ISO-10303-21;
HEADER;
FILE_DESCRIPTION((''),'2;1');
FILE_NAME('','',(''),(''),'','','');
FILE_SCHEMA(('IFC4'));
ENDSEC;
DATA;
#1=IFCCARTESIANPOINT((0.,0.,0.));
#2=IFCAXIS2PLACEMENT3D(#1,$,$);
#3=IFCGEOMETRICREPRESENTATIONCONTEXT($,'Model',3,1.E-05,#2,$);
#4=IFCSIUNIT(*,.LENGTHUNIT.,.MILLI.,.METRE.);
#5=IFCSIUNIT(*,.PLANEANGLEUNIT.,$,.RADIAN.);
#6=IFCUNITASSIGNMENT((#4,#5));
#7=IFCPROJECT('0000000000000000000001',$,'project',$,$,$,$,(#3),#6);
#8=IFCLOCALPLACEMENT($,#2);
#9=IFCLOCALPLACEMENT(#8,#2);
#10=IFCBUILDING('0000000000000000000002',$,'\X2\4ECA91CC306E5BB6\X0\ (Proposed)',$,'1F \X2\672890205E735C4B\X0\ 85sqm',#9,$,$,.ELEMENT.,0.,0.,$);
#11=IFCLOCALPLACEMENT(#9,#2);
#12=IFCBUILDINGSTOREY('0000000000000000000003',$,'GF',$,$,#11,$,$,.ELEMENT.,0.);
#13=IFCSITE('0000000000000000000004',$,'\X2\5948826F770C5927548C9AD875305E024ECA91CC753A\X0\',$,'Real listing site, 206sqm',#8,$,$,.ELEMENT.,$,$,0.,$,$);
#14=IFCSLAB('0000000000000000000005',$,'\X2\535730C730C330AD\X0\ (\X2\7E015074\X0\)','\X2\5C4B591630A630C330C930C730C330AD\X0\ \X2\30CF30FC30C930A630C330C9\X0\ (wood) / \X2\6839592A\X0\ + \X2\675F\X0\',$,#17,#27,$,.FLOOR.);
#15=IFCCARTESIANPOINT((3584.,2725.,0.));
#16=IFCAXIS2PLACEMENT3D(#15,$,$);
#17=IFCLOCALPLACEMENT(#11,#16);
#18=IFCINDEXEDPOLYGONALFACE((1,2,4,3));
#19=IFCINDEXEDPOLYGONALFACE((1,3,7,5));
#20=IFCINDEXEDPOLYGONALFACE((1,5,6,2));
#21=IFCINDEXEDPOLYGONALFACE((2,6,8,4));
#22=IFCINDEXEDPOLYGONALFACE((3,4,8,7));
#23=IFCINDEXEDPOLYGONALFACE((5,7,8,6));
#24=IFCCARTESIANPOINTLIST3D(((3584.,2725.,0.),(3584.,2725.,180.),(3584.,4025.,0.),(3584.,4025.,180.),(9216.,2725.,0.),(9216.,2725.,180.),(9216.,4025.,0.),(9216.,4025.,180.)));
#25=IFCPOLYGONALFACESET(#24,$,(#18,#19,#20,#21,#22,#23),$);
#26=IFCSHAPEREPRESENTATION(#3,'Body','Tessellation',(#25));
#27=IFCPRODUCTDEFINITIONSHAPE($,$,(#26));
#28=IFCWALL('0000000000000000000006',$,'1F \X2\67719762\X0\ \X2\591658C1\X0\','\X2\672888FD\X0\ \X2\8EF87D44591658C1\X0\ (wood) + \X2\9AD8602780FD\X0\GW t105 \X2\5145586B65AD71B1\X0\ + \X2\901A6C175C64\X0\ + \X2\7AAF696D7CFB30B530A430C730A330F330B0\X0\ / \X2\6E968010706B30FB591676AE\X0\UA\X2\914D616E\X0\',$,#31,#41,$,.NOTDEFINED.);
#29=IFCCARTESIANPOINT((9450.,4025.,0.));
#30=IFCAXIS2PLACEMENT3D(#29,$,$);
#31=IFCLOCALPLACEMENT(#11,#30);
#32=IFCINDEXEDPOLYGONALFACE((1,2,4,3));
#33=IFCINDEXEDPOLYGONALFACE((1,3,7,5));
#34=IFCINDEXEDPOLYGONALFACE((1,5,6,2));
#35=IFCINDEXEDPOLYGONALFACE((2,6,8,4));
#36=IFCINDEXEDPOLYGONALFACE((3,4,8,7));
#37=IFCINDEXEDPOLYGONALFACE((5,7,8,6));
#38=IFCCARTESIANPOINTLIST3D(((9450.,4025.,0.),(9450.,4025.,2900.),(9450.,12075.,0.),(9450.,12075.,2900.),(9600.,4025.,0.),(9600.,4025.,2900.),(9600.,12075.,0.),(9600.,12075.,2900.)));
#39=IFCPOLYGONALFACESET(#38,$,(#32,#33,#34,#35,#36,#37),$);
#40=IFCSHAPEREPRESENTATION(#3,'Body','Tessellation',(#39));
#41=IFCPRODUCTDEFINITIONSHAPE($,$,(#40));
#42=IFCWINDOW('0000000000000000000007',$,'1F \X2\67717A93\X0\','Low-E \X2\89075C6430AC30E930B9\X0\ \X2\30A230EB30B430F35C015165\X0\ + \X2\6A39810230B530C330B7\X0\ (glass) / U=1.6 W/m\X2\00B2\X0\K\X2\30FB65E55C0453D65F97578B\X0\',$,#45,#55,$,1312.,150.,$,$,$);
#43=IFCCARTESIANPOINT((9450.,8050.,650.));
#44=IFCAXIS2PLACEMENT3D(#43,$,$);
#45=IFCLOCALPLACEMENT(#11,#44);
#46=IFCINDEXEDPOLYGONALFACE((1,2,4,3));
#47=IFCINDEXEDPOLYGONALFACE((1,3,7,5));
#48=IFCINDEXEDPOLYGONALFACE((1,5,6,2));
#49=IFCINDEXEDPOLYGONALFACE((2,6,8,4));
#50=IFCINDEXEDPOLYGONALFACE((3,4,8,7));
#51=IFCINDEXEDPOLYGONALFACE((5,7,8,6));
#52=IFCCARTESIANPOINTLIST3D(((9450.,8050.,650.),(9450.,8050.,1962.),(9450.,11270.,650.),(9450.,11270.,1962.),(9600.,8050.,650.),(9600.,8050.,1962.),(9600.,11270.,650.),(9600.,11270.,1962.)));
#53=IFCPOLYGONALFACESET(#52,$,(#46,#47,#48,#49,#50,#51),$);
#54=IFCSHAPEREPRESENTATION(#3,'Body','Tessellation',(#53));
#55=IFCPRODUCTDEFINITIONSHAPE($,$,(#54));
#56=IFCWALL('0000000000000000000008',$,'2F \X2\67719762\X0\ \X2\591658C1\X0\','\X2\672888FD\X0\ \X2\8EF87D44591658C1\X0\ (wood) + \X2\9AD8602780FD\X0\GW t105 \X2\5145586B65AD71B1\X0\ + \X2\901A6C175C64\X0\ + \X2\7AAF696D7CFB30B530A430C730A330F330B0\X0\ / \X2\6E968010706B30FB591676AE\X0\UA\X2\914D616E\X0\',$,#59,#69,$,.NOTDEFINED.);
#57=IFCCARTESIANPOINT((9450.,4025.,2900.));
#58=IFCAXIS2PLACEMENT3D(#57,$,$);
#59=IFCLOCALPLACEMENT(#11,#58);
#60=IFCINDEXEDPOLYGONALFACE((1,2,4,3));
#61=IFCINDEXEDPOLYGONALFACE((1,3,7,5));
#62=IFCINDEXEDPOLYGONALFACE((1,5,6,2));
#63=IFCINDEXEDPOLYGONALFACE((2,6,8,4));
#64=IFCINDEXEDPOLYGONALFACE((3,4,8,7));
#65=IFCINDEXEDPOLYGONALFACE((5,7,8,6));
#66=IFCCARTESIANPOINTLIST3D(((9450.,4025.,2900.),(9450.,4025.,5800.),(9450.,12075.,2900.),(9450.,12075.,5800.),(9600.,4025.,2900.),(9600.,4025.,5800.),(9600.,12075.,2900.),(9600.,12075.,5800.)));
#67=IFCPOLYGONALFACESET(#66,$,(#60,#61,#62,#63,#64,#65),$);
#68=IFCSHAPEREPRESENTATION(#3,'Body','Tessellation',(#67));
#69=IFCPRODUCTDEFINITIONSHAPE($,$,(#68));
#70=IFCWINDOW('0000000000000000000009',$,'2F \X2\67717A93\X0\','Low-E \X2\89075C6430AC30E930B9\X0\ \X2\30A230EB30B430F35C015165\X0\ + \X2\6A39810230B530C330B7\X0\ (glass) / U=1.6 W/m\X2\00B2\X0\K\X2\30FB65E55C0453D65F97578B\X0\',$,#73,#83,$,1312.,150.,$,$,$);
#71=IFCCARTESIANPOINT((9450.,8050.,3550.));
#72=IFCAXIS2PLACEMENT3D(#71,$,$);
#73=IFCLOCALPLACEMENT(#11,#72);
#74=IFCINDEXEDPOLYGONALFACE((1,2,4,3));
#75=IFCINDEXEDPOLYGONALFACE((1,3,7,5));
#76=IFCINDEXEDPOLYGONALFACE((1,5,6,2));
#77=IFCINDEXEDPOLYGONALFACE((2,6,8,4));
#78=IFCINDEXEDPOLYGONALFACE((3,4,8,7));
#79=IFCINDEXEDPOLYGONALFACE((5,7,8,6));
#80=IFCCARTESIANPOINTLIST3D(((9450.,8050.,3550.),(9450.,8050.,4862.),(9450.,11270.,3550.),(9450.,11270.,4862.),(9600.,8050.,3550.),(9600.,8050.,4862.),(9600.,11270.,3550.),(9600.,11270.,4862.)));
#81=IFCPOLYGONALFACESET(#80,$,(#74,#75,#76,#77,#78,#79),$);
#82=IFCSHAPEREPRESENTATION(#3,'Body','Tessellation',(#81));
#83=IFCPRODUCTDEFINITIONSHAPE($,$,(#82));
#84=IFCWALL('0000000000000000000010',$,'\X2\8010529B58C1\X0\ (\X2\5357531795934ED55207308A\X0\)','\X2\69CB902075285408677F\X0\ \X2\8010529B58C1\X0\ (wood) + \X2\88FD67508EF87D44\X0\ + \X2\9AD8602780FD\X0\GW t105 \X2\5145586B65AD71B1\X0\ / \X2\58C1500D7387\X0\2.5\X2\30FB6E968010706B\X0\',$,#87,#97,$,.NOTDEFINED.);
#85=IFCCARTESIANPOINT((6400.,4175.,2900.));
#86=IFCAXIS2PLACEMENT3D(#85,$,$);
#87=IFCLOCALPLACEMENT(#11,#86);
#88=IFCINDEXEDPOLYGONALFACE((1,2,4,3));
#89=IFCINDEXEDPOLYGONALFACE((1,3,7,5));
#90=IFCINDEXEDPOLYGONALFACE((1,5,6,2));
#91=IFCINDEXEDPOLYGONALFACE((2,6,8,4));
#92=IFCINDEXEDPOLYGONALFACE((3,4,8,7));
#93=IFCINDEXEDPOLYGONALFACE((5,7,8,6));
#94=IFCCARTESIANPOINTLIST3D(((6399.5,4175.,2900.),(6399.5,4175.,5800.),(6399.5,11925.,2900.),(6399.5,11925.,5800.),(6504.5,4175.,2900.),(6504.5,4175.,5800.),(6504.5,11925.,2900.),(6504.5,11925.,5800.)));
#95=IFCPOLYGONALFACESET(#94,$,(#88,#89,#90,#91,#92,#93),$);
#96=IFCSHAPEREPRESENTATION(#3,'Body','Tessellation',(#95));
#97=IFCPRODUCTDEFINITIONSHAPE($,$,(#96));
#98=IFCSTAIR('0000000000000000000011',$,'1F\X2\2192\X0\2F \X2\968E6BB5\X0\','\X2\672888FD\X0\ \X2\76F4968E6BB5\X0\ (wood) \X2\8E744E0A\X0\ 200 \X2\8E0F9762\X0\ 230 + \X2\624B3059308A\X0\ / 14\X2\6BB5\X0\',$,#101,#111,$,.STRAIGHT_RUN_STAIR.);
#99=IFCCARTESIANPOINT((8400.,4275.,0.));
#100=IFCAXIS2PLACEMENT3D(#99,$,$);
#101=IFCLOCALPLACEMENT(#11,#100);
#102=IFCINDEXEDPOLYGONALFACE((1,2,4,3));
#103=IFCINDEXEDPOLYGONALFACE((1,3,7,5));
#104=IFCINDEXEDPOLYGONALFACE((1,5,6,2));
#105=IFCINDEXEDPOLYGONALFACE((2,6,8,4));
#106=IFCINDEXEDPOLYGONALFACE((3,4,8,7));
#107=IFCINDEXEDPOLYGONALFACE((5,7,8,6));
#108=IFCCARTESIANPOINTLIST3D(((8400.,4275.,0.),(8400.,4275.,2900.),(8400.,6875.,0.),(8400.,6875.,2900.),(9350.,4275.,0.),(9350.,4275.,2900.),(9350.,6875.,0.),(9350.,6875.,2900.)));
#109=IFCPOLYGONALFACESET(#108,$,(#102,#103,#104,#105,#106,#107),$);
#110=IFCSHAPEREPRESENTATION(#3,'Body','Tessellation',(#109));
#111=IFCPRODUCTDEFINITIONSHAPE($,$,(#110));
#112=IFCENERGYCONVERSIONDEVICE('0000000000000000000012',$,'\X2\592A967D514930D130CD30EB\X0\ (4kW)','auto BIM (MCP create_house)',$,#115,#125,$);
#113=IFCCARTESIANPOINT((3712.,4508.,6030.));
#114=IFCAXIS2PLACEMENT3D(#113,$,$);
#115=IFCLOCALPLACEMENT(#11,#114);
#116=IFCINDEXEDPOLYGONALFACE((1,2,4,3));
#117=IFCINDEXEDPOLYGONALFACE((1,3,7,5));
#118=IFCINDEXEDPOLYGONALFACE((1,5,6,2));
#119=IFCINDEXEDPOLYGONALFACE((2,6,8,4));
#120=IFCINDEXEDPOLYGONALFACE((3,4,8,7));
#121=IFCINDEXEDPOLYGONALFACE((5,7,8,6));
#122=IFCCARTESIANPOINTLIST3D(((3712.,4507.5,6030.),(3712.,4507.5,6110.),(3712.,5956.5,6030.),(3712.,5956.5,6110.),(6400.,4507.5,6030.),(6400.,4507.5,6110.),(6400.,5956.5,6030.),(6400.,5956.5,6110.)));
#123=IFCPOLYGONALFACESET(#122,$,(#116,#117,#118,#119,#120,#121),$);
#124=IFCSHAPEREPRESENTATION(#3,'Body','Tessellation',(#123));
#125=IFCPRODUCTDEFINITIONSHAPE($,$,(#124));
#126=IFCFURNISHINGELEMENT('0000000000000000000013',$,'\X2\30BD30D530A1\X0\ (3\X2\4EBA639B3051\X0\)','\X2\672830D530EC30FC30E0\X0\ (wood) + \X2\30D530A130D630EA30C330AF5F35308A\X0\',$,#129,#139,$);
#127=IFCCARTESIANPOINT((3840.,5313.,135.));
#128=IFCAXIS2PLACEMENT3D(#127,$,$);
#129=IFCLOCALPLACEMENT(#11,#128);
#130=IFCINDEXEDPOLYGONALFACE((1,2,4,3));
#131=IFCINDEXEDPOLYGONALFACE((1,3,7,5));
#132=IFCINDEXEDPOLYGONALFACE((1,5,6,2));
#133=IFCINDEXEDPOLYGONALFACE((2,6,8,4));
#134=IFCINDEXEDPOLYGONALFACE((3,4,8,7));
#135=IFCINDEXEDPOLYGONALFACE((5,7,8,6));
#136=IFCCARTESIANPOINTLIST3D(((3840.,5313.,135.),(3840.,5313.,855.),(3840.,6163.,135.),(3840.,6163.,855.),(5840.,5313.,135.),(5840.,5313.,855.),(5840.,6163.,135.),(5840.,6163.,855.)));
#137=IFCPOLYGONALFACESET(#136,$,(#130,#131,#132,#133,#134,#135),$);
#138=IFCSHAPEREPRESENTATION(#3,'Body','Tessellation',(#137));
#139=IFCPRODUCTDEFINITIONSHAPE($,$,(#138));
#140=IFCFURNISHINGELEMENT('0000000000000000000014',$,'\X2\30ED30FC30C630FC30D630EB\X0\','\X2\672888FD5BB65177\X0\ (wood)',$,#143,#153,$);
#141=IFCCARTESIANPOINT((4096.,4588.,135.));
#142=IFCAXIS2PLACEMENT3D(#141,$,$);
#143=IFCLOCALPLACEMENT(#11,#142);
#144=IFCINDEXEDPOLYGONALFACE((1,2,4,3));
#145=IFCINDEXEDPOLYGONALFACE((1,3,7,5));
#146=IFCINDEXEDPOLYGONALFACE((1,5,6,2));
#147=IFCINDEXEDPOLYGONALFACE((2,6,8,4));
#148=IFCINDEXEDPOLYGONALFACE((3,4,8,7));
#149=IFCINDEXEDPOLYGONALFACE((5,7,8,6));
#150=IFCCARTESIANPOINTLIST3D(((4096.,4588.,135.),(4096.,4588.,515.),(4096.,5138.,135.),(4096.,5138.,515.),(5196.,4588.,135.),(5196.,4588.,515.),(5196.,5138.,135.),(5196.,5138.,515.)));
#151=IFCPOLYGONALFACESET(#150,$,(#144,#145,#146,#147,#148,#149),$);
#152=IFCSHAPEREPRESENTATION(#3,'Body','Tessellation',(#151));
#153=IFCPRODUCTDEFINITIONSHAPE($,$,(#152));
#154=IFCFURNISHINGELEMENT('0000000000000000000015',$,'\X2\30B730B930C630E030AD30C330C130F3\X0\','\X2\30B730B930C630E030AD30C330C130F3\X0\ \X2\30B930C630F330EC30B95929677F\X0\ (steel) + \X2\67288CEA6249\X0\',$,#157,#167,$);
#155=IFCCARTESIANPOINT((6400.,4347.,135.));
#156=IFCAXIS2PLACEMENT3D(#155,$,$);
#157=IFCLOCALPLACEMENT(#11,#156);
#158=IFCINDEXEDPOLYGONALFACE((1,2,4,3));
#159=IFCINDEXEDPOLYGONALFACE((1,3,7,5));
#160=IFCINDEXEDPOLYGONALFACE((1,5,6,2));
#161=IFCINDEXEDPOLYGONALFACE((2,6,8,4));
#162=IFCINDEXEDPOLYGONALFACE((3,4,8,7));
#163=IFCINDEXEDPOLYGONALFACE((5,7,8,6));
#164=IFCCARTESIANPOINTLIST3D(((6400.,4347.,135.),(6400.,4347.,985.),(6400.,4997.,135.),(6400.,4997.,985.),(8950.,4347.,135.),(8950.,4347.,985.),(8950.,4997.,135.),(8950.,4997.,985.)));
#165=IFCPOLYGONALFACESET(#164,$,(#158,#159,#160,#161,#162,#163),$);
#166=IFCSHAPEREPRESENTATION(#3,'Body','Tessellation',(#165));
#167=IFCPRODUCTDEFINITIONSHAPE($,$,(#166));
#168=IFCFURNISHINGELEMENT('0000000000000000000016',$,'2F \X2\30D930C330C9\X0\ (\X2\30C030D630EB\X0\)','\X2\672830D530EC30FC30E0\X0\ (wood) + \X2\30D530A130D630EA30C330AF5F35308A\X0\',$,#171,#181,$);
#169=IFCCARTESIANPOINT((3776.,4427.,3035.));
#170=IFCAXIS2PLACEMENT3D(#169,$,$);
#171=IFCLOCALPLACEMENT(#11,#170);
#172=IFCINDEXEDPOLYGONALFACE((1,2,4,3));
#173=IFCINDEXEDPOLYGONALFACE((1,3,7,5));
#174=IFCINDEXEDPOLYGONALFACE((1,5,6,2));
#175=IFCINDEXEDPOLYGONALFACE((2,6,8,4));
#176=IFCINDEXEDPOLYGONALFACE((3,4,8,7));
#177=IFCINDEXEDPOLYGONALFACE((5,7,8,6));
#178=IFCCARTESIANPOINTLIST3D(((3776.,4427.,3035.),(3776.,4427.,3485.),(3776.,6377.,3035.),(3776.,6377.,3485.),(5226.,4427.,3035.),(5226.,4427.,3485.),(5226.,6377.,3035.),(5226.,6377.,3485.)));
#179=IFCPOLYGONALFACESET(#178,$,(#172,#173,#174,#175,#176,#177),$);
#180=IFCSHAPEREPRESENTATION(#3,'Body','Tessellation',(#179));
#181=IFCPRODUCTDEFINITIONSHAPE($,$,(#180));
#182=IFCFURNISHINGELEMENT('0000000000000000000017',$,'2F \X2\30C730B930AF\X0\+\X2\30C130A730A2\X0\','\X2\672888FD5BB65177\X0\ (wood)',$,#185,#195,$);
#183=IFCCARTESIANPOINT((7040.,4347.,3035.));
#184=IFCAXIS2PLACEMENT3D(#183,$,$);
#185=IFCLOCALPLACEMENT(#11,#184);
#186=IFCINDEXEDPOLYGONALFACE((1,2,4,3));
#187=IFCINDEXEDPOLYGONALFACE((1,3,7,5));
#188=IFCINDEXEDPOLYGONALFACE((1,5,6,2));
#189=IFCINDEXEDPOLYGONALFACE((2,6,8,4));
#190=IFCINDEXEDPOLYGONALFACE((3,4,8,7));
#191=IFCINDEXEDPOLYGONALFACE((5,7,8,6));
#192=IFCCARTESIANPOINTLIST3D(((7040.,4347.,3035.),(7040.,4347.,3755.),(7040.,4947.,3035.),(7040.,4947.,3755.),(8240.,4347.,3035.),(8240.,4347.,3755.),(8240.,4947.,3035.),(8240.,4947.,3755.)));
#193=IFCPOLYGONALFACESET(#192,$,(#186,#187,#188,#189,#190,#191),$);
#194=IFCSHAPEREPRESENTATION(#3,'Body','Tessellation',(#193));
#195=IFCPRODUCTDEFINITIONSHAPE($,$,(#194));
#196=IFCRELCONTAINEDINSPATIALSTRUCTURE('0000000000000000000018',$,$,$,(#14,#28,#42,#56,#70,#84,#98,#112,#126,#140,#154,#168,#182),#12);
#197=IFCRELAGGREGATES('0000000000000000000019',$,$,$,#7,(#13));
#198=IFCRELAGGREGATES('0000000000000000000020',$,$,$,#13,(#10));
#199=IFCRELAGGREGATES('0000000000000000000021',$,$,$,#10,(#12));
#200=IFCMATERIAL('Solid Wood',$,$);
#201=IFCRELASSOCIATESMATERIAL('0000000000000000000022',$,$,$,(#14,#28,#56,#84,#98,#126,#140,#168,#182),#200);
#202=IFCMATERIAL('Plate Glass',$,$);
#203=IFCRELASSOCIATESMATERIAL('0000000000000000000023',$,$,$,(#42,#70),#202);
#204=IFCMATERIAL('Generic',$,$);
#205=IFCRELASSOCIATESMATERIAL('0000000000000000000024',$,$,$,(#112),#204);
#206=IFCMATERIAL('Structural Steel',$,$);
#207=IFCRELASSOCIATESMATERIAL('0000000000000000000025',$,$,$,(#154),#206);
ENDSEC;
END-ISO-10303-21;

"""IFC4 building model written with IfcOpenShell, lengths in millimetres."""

from ifc_helpers import new_model, si_unit, frame, frame_2d, origin, place, context, project, spatial, rectangle, extrude, material, element, fill, save


model = new_model("IFC4")

# Units and contexts
model_context = context("Model", 3, precision=1e-05, world=origin())
ifc_project = project(units=[si_unit("LENGTHUNIT", "METRE", prefix="MILLI"), si_unit("PLANEANGLEUNIT", "RADIAN")], contexts=[model_context])

# Site, building, storey
site_placement = place(None, origin())
site = spatial("IfcSite", under=ifc_project, at=site_placement, Name="奈良県大和高田市今里町", ObjectType="Real listing site, 206sqm", CompositionType="ELEMENT", RefElevation=0.0)
building_placement = place(site_placement, origin())
building = spatial("IfcBuilding", under=site, at=building_placement, Name="今里の家 (Proposed)", ObjectType="1F 木造平屋 85sqm", CompositionType="ELEMENT", ElevationOfRefHeight=0.0, ElevationOfTerrain=0.0)
storey_placement = place(building_placement, origin())
storey = spatial("IfcBuildingStorey", under=building, at=storey_placement, Name="GF", CompositionType="ELEMENT", Elevation=0.0)

# Slab
ifc_material_1 = material(Name="Solid Wood")
slab_placement = place(storey_placement, frame((3584.0, 2725.0, 0.0)))
element("IfcSlab", 1, at=slab_placement, inside=storey, material=ifc_material_1, Name="南デッキ (縁側)", Description="屋外ウッドデッキ ハードウッド (wood) / 根太 + 束", PredefinedType="FLOOR", context=model_context, shape_type="SweptSolid", body=[
    extrude(rectangle(XDim=5632.0, YDim=1300.0, at=frame_2d((2816.0, 650.0))), frame((3584.0, 2725.0, 0.0)), (0.0, 0.0, 1.0), 180.0),
])

# Wall, opening, window
wall_1_placement = place(storey_placement, frame((9450.0, 4025.0, 0.0)))
wall_1 = element("IfcWall", 2, at=wall_1_placement, inside=storey, material=ifc_material_1, Name="1F 東面 外壁", Description="木製 軸組外壁 (wood) + 高性能GW t105 充填断熱 + 通気層 + 窯業系サイディング / 準耐火・外皮UA配慮", PredefinedType="NOTDEFINED", context=model_context, shape_type="SweptSolid", body=[
    extrude(rectangle(XDim=150.0, YDim=8050.0, at=frame_2d((75.0, 4025.0))), frame((9450.0, 4025.0, 0.0)), (0.0, 0.0, 1.0), 2900.0),
])
opening_1_placement = place(storey_placement, frame((9450.0, 8050.0, 650.0)))
opening_1 = element("IfcOpeningElement", 3, at=opening_1_placement, cuts=wall_1, PredefinedType="NOTDEFINED", context=model_context, shape_type="SweptSolid", body=[
    extrude(rectangle(XDim=150.0, YDim=3220.0, at=frame_2d((75.0, 1610.0))), frame((9450.0, 8050.0, 650.0)), (0.0, 0.0, 1.0), 1312.0),
])
ifc_material_2 = material(Name="Plate Glass")
window_1_placement = place(storey_placement, frame((9450.0, 8050.0, 650.0)))
window_1 = element("IfcWindow", 4, at=window_1_placement, inside=storey, material=ifc_material_2, Name="1F 東窓", Description="Low-E 複層ガラス アルゴン封入 + 樹脂サッシ (glass) / U=1.6 W/m²K・日射取得型", OverallHeight=1312.0, OverallWidth=150.0, context=model_context, shape_type="SweptSolid", body=[
    extrude(rectangle(XDim=150.0, YDim=3220.0, at=frame_2d((75.0, 1610.0))), frame((9450.0, 8050.0, 650.0)), (0.0, 0.0, 1.0), 1312.0),
])
fill(opening_1, window_1)

# Wall, opening, window
wall_2_placement = place(storey_placement, frame((9450.0, 4025.0, 2900.0)))
wall_2 = element("IfcWall", 5, at=wall_2_placement, inside=storey, material=ifc_material_1, Name="2F 東面 外壁", Description="木製 軸組外壁 (wood) + 高性能GW t105 充填断熱 + 通気層 + 窯業系サイディング / 準耐火・外皮UA配慮", PredefinedType="NOTDEFINED", context=model_context, shape_type="SweptSolid", body=[
    extrude(rectangle(XDim=150.0, YDim=8050.0, at=frame_2d((75.0, 4025.0))), frame((9450.0, 4025.0, 2900.0)), (0.0, 0.0, 1.0), 2900.0),
])
opening_2_placement = place(storey_placement, frame((9450.0, 8050.0, 3550.0)))
opening_2 = element("IfcOpeningElement", 6, at=opening_2_placement, cuts=wall_2, PredefinedType="NOTDEFINED", context=model_context, shape_type="SweptSolid", body=[
    extrude(rectangle(XDim=150.0, YDim=3220.0, at=frame_2d((75.0, 1610.0))), frame((9450.0, 8050.0, 3550.0)), (0.0, 0.0, 1.0), 1312.0),
])
window_2_placement = place(storey_placement, frame((9450.0, 8050.0, 3550.0)))
window_2 = element("IfcWindow", 7, at=window_2_placement, inside=storey, material=ifc_material_2, Name="2F 東窓", Description="Low-E 複層ガラス アルゴン封入 + 樹脂サッシ (glass) / U=1.6 W/m²K・日射取得型", OverallHeight=1312.0, OverallWidth=150.0, context=model_context, shape_type="SweptSolid", body=[
    extrude(rectangle(XDim=150.0, YDim=3220.0, at=frame_2d((75.0, 1610.0))), frame((9450.0, 8050.0, 3550.0)), (0.0, 0.0, 1.0), 1312.0),
])
fill(opening_2, window_2)

# Wall
wall_3_placement = place(storey_placement, frame((6400.0, 4175.0, 2900.0)))
element("IfcWall", 8, at=wall_3_placement, inside=storey, material=ifc_material_1, Name="耐力壁 (南北間仕切り)", Description="構造用合板 耐力壁 (wood) + 製材軸組 + 高性能GW t105 充填断熱 / 壁倍率2.5・準耐火", PredefinedType="NOTDEFINED", context=model_context, shape_type="SweptSolid", body=[
    extrude(rectangle(XDim=105.0, YDim=7750.0, at=frame_2d((52.0, 3875.0))), frame((6400.0, 4175.0, 2900.0)), (0.0, 0.0, 1.0), 2900.0),
])

# Stair
stair_placement = place(storey_placement, frame((8400.0, 4275.0, 0.0)))
element("IfcStair", 9, at=stair_placement, inside=storey, material=ifc_material_1, Name="1F→2F 階段", Description="木製 直階段 (wood) 蹴上 200 踏面 230 + 手すり / 14段", PredefinedType="STRAIGHT_RUN_STAIR", context=model_context, shape_type="SweptSolid", body=[
    extrude(rectangle(XDim=950.0, YDim=2600.0, at=frame_2d((475.0, 1300.0))), frame((8400.0, 4275.0, 0.0)), (0.0, 0.0, 1.0), 2900.0),
])

# Energy conversion device
ifc_material_3 = material(Name="Generic")
energy_conversion_device_placement = place(storey_placement, frame((3712.0, 4508.0, 6030.0)))
element("IfcEnergyConversionDevice", 10, at=energy_conversion_device_placement, inside=storey, material=ifc_material_3, Name="太陽光パネル (4kW)", Description="auto BIM (MCP create_house)", context=model_context, shape_type="SweptSolid", body=[
    extrude(rectangle(XDim=2688.0, YDim=1449.0, at=frame_2d((1344.0, 724.0))), frame((3712.0, 4508.0, 6030.0)), (0.0, 0.0, 1.0), 80.0),
])

# Furnishing elements
furnishing_1_placement = place(storey_placement, frame((3840.0, 5313.0, 135.0)))
element("IfcFurnishingElement", 11, at=furnishing_1_placement, inside=storey, material=ifc_material_1, Name="ソファ (3人掛け)", Description="木フレーム (wood) + ファブリック張り", context=model_context, shape_type="SweptSolid", body=[
    extrude(rectangle(XDim=2000.0, YDim=850.0, at=frame_2d((1000.0, 425.0))), frame((3840.0, 5313.0, 135.0)), (0.0, 0.0, 1.0), 720.0),
])
furnishing_2_placement = place(storey_placement, frame((4096.0, 4588.0, 135.0)))
element("IfcFurnishingElement", 12, at=furnishing_2_placement, inside=storey, material=ifc_material_1, Name="ローテーブル", Description="木製家具 (wood)", context=model_context, shape_type="SweptSolid", body=[
    extrude(rectangle(XDim=1100.0, YDim=550.0, at=frame_2d((550.0, 275.0))), frame((4096.0, 4588.0, 135.0)), (0.0, 0.0, 1.0), 380.0),
])
ifc_material_4 = material(Name="Structural Steel")
furnishing_3_placement = place(storey_placement, frame((6400.0, 4347.0, 135.0)))
element("IfcFurnishingElement", 13, at=furnishing_3_placement, inside=storey, material=ifc_material_4, Name="システムキッチン", Description="システムキッチン ステンレス天板 (steel) + 木質扉", context=model_context, shape_type="SweptSolid", body=[
    extrude(rectangle(XDim=2550.0, YDim=650.0, at=frame_2d((1275.0, 325.0))), frame((6400.0, 4347.0, 135.0)), (0.0, 0.0, 1.0), 850.0),
])
furnishing_4_placement = place(storey_placement, frame((3776.0, 4427.0, 3035.0)))
element("IfcFurnishingElement", 14, at=furnishing_4_placement, inside=storey, material=ifc_material_1, Name="2F ベッド (ダブル)", Description="木フレーム (wood) + ファブリック張り", context=model_context, shape_type="SweptSolid", body=[
    extrude(rectangle(XDim=1450.0, YDim=1950.0, at=frame_2d((725.0, 975.0))), frame((3776.0, 4427.0, 3035.0)), (0.0, 0.0, 1.0), 450.0),
])
furnishing_5_placement = place(storey_placement, frame((7040.0, 4347.0, 3035.0)))
element("IfcFurnishingElement", 15, at=furnishing_5_placement, inside=storey, material=ifc_material_1, Name="2F デスク+チェア", Description="木製家具 (wood)", context=model_context, shape_type="SweptSolid", body=[
    extrude(rectangle(XDim=1200.0, YDim=600.0, at=frame_2d((600.0, 300.0))), frame((7040.0, 4347.0, 3035.0)), (0.0, 0.0, 1.0), 720.0),
])

save(model, "model.ifc")
